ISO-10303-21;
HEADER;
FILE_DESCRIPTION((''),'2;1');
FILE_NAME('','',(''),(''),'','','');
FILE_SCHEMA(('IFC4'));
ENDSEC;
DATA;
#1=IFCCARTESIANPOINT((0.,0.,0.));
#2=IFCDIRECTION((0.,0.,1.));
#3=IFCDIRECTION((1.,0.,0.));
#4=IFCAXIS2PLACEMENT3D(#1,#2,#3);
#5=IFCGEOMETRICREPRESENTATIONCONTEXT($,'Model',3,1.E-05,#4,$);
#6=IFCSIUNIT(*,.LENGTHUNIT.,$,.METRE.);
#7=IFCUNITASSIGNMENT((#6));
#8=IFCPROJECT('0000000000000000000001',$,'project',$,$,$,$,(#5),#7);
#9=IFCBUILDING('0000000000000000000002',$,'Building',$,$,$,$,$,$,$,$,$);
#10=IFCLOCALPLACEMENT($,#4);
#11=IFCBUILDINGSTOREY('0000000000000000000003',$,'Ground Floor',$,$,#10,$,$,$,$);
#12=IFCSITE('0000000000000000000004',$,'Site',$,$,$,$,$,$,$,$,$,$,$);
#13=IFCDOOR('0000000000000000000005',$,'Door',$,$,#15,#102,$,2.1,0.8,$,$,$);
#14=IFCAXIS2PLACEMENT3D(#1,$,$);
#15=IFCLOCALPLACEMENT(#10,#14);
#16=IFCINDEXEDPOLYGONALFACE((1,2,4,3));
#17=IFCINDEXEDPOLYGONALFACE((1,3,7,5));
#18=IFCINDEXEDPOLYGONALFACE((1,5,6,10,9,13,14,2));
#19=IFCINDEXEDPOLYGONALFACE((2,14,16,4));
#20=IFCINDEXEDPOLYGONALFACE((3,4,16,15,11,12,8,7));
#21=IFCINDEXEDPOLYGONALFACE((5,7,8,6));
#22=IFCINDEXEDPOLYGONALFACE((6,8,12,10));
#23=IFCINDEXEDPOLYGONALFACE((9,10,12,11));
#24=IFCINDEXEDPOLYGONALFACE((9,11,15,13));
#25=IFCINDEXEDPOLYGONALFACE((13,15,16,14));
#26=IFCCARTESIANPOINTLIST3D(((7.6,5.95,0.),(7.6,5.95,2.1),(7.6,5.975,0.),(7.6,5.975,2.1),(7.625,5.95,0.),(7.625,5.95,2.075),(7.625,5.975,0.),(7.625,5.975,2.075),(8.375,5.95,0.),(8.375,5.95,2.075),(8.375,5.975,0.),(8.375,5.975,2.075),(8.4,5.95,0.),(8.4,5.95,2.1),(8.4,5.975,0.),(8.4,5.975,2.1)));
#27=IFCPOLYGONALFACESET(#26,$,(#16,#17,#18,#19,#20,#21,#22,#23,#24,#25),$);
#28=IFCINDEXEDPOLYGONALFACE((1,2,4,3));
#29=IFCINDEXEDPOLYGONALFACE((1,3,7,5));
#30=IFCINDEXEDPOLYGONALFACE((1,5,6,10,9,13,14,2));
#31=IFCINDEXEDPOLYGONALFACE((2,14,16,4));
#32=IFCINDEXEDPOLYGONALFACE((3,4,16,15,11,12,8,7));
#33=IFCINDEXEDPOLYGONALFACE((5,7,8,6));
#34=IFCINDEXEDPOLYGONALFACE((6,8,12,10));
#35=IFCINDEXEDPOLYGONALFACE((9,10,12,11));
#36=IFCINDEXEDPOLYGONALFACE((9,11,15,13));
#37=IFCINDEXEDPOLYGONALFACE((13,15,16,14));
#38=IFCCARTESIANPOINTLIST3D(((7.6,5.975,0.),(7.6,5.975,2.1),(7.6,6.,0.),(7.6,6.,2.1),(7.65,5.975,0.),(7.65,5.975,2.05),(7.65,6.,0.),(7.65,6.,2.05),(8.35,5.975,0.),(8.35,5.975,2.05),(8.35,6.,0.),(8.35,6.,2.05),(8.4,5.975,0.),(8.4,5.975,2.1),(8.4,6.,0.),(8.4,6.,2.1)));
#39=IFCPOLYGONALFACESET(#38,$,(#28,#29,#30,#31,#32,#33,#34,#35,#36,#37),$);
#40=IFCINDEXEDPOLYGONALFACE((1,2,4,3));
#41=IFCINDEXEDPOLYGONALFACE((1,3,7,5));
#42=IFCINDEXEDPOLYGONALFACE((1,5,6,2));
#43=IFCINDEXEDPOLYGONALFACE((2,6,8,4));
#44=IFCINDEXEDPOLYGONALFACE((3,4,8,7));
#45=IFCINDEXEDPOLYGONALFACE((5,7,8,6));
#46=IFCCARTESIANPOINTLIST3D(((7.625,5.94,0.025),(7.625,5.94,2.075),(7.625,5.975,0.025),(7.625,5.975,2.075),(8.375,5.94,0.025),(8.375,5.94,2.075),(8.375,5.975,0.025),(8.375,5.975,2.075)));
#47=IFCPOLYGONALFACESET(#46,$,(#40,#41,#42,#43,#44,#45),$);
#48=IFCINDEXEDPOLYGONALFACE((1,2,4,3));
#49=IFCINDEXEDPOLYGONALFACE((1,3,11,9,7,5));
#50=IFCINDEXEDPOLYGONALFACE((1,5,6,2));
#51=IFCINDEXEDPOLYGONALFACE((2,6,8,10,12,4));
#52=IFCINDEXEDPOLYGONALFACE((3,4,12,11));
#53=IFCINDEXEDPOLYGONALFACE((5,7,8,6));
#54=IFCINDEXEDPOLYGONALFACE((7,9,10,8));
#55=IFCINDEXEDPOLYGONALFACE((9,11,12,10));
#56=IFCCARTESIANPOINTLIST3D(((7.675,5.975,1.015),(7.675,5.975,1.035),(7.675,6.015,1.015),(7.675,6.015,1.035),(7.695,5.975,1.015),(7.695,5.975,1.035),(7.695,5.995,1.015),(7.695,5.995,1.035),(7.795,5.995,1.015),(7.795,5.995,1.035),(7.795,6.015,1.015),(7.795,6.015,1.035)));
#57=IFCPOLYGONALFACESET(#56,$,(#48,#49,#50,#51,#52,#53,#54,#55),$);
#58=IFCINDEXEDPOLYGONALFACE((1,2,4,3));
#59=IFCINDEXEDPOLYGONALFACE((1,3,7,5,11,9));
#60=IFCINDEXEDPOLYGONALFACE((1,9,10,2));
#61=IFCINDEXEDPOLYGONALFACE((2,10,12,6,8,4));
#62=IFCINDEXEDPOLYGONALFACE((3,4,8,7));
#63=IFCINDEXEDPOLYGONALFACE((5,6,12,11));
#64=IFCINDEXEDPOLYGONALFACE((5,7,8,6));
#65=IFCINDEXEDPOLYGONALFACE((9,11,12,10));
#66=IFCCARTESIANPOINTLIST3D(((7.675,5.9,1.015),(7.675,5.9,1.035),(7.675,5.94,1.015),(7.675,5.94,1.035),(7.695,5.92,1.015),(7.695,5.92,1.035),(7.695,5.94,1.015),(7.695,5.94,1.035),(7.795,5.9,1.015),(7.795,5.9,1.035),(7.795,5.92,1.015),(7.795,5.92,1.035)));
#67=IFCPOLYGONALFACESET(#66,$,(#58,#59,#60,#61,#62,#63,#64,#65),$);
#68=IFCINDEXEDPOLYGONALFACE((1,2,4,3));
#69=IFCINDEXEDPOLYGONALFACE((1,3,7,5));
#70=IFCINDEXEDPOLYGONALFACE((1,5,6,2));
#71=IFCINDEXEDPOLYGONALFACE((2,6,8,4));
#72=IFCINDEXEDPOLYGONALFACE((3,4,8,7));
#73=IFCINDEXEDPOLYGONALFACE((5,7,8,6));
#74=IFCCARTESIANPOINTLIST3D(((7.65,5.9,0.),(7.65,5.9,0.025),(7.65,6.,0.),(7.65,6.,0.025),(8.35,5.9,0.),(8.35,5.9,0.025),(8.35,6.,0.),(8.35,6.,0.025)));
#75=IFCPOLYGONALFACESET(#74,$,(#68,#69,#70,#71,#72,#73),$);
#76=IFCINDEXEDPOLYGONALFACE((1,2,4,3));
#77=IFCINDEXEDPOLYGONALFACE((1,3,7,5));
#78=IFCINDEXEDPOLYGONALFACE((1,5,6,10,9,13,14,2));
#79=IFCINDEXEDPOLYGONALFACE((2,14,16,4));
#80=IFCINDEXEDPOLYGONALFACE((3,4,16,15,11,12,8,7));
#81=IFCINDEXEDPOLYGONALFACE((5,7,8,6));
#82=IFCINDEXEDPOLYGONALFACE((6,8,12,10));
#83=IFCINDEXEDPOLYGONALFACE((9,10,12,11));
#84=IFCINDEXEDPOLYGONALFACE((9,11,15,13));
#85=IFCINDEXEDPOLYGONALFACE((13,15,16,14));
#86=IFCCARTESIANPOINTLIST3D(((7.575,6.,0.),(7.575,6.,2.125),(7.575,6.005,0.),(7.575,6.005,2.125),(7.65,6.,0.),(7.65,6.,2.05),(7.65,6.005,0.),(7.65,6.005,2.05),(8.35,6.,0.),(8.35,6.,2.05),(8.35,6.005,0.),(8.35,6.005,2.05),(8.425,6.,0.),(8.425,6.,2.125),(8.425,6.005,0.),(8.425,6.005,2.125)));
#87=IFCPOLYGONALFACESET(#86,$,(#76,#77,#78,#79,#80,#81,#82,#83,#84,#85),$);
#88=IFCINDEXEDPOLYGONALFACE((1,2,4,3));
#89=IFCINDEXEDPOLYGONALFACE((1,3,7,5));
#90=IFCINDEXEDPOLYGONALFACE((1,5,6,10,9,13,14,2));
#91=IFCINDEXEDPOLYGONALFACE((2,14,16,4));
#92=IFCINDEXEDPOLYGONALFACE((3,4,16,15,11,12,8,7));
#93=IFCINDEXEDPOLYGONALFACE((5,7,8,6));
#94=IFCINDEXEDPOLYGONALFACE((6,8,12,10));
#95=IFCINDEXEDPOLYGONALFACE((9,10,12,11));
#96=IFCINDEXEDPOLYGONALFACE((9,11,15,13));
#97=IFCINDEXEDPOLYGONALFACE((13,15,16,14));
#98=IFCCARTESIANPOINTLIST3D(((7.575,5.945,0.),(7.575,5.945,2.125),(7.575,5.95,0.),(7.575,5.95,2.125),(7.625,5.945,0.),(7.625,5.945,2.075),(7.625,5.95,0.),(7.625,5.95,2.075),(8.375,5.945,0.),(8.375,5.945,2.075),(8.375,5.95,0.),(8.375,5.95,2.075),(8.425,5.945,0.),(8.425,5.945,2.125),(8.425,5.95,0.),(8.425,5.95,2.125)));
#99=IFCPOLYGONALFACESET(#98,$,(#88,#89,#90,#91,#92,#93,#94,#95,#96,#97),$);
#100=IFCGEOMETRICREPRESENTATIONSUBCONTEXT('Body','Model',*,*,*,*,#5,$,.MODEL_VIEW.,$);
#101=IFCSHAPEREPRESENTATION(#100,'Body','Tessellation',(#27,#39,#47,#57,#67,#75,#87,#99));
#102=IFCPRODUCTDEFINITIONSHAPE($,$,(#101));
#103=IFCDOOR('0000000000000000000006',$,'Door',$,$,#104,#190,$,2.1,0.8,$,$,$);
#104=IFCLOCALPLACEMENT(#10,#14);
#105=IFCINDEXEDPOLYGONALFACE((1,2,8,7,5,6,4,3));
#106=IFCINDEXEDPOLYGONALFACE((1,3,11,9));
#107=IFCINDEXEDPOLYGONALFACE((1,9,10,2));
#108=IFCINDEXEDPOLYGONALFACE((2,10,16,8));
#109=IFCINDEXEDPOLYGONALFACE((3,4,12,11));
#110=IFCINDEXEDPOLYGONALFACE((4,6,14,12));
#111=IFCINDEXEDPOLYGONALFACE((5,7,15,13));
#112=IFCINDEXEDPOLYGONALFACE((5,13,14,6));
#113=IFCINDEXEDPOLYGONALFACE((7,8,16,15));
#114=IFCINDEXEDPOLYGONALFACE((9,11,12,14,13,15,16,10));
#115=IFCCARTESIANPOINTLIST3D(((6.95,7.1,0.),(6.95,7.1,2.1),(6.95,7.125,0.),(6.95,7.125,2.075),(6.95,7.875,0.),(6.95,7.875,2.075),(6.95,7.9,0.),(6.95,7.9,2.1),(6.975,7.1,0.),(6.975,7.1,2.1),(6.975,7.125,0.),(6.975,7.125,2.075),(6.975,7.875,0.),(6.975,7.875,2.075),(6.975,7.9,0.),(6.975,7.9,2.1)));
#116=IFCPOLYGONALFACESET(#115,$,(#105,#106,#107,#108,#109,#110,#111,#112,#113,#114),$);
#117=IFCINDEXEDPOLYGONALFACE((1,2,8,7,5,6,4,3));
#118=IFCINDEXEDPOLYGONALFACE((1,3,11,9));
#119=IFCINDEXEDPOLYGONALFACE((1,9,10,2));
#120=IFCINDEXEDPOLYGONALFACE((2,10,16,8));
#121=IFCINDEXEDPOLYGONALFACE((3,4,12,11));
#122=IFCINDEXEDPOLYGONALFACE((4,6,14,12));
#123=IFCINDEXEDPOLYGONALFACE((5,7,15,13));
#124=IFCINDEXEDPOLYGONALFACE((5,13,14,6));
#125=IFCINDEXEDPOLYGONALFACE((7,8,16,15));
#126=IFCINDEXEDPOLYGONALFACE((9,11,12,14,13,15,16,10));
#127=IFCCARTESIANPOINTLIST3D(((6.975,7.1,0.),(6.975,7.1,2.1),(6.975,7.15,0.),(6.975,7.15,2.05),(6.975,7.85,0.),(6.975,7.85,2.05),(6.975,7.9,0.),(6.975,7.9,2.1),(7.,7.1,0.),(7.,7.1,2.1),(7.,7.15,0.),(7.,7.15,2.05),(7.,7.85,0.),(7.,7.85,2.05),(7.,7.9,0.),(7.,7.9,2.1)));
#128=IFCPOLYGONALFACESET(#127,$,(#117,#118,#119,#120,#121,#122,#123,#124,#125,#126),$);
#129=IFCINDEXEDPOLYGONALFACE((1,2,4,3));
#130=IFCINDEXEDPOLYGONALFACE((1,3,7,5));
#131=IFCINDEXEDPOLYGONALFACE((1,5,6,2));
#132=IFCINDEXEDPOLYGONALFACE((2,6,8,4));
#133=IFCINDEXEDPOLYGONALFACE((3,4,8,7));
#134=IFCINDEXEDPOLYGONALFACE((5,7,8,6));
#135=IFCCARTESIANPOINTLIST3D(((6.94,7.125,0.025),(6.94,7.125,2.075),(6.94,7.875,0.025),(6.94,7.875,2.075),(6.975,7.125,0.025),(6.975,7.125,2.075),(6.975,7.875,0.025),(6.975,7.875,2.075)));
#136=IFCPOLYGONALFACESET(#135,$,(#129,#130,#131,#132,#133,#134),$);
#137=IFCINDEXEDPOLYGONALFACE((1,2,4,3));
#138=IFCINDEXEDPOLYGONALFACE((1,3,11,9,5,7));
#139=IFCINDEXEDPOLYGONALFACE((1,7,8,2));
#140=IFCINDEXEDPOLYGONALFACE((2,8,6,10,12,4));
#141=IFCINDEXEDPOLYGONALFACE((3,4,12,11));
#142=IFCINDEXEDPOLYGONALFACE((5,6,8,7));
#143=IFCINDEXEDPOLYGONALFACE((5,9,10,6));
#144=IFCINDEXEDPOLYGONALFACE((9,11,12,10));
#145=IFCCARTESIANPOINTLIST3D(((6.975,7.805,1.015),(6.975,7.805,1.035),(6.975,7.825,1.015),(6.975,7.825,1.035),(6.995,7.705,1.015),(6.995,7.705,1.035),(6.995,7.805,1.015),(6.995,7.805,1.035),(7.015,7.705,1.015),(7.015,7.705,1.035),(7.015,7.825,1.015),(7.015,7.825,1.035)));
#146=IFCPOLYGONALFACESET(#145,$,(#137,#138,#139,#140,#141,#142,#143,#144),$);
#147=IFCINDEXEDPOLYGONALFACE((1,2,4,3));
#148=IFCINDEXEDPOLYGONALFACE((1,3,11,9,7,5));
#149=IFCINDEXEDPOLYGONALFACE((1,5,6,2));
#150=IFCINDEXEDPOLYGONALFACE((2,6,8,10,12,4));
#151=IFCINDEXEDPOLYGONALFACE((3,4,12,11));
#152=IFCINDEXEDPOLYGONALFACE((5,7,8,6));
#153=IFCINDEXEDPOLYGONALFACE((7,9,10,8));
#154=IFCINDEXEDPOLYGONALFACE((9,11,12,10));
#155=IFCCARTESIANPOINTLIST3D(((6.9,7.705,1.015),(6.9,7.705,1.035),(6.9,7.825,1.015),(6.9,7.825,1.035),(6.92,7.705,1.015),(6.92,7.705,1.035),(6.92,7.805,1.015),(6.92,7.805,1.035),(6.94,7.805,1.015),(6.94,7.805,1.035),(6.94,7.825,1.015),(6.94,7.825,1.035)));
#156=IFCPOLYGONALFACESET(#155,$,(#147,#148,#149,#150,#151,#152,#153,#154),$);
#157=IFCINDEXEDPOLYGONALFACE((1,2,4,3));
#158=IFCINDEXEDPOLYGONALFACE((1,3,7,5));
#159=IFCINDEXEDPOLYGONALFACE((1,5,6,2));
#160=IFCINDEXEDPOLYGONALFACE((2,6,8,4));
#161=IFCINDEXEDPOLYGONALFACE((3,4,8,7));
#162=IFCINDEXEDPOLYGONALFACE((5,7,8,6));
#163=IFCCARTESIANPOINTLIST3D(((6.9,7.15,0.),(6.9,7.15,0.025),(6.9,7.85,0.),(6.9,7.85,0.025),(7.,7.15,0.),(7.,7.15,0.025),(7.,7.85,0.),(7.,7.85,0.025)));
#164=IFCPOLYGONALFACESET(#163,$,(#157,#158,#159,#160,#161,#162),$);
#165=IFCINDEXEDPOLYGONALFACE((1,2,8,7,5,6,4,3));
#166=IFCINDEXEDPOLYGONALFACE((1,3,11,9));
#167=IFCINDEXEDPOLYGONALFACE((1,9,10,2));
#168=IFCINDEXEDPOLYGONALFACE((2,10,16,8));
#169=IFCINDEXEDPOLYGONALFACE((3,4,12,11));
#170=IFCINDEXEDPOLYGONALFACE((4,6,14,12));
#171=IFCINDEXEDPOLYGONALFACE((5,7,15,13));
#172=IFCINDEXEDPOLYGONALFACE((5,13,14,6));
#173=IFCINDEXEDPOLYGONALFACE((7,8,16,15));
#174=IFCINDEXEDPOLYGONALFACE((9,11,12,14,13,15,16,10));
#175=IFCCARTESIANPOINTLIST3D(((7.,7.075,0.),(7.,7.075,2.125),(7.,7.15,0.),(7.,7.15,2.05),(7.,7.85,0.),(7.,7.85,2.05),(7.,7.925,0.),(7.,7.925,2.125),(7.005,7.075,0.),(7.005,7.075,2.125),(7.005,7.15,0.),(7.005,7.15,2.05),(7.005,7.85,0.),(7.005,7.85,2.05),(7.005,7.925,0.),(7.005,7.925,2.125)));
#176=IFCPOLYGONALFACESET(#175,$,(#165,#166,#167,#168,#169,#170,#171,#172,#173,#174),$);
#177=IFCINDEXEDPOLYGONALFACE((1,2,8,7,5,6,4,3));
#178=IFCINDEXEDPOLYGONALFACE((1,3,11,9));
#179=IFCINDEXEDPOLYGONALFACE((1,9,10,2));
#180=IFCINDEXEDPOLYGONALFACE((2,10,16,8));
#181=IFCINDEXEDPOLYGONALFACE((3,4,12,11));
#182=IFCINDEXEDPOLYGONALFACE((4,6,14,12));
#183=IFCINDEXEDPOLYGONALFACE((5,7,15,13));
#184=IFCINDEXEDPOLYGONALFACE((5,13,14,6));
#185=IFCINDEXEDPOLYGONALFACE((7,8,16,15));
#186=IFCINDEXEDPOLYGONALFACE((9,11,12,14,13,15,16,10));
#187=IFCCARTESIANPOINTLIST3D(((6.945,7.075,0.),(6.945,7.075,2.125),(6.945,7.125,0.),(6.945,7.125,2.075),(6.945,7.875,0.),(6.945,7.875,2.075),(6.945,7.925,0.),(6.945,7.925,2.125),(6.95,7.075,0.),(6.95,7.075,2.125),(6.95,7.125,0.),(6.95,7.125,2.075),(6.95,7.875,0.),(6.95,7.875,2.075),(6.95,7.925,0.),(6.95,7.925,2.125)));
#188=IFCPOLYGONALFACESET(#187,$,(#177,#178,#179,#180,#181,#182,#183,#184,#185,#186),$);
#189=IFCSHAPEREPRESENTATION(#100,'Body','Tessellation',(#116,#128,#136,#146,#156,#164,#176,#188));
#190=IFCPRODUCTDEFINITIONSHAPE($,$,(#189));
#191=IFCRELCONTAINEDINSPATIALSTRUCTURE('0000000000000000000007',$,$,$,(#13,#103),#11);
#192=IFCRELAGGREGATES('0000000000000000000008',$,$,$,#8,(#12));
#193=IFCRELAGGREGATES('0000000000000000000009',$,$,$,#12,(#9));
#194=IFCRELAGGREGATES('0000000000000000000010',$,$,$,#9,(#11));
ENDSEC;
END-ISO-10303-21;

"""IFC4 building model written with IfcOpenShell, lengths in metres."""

from ifc_helpers import new_model, si_unit, frame, origin_with_axes, place, context, subcontext, project, spatial, line, indexed_curve, outline, extrude, element, save


model = new_model("IFC4")

# Units and contexts
model_context = context("Model", 3, precision=1e-05, world=origin_with_axes())
body_context = subcontext(model_context, "Body", "Model", "MODEL_VIEW")
ifc_project = project(units=[si_unit("LENGTHUNIT", "METRE")], contexts=[model_context])

# Site, building, storey
site = spatial("IfcSite", under=ifc_project, Name="Site")
building = spatial("IfcBuilding", under=site, Name="Building")
storey_placement = place(None, origin_with_axes())
storey = spatial("IfcBuildingStorey", under=building, at=storey_placement, Name="Ground Floor")

# Doors
door_1_placement = place(storey_placement, frame((8.4, 6.0, 0.0), z_axis=(0.0, 0.0, 1.0), x_axis=(-1.0, 0.0, 0.0)))
element("IfcDoor", 1, at=door_1_placement, inside=storey, Name="Door", OverallHeight=2.1, OverallWidth=0.8, context=body_context, shape_type="SweptSolid", body=[
    extrude(outline(indexed_curve([(0.0, 0.0), (0.0, 2.1), (0.8, 2.1), (0.8, 0.0), (0.775, 0.0), (0.775, 2.075), (0.025, 2.075), (0.025, 0.0)], segments=[line(1, 2, 3, 4, 5, 6, 7, 8, 1)])), frame((0.0, 0.025, 0.0), z_axis=(0.0, -1.0, 0.0), x_axis=(1.0, 0.0, 0.0)), (0.0, 0.0, -1.0), 0.025),
    extrude(outline(indexed_curve([(0.0, 0.0), (0.0, 2.1), (0.8, 2.1), (0.8, 0.0), (0.75, 0.0), (0.75, 2.05), (0.05, 2.05), (0.05, 0.0)], segments=[line(1, 2, 3, 4, 5, 6, 7, 8, 1)])), frame((0.0, 0.0, 0.0), z_axis=(0.0, -1.0, 0.0), x_axis=(1.0, 0.0, 0.0)), (0.0, 0.0, -1.0), 0.025),
    extrude(outline(indexed_curve([(0.0, 0.0), (0.75, 0.0), (0.75, 0.035), (0.0, 0.035)], segments=[line(1, 2, 3, 4, 1)])), frame((0.025, 0.025, 0.025), z_axis=(0.0, 0.0, 1.0), x_axis=(1.0, 0.0, 0.0)), (0.0, 0.0, 1.0), 2.05),
    extrude(outline(indexed_curve([(0.0, 0.0), (0.0, -0.04), (-0.12, -0.04), (-0.12, -0.02), (-0.02, -0.02), (-0.02, 0.0)], segments=[line(1, 2, 3, 4, 5, 6, 1)])), frame((0.725, 0.025, 1.015), z_axis=(0.0, 0.0, 1.0), x_axis=(1.0, 0.0, 0.0)), (0.0, 0.0, 1.0), 0.02),
    extrude(outline(indexed_curve([(0.0, 0.0), (0.0, 0.04), (-0.12, 0.04), (-0.12, 0.02), (-0.02, 0.02), (-0.02, 0.0)], segments=[line(1, 2, 3, 4, 5, 6, 1)])), frame((0.725, 0.06, 1.015), z_axis=(0.0, 0.0, 1.0), x_axis=(1.0, 0.0, 0.0)), (0.0, 0.0, 1.0), 0.02),
    extrude(outline(indexed_curve([(0.0, 0.0), (0.7, 0.0), (0.7, 0.1), (0.0, 0.1)], segments=[line(1, 2, 3, 4, 1)])), frame((0.05, 0.0, 0.0), z_axis=(0.0, 0.0, 1.0), x_axis=(1.0, 0.0, 0.0)), (0.0, 0.0, 1.0), 0.025),
    extrude(outline(indexed_curve([(0.0, 0.0), (0.0, 2.125), (0.85, 2.125), (0.85, 0.0), (0.775, 0.0), (0.775, 2.05), (0.075, 2.05), (0.075, 0.0)], segments=[line(1, 2, 3, 4, 5, 6, 7, 8, 1)])), frame((-0.025, -0.005, 0.0), z_axis=(0.0, -1.0, 0.0), x_axis=(1.0, 0.0, 0.0)), (0.0, 0.0, -1.0), 0.005),
    extrude(outline(indexed_curve([(0.0, 0.0), (0.0, 2.125), (0.85, 2.125), (0.85, 0.0), (0.8, 0.0), (0.8, 2.075), (0.05, 2.075), (0.05, 0.0)], segments=[line(1, 2, 3, 4, 5, 6, 7, 8, 1)])), frame((-0.025, 0.05, 0.0), z_axis=(0.0, -1.0, 0.0), x_axis=(1.0, 0.0, 0.0)), (0.0, 0.0, -1.0), 0.005),
])
door_2_placement = place(storey_placement, frame((7.0, 7.1, 0.0), z_axis=(0.0, 0.0, 1.0), x_axis=(0.0, 1.0, 0.0)))
element("IfcDoor", 2, at=door_2_placement, inside=storey, Name="Door", OverallHeight=2.1, OverallWidth=0.8, context=body_context, shape_type="SweptSolid", body=[
    extrude(outline(indexed_curve([(0.0, 0.0), (0.0, 2.1), (0.8, 2.1), (0.8, 0.0), (0.775, 0.0), (0.775, 2.075), (0.025, 2.075), (0.025, 0.0)], segments=[line(1, 2, 3, 4, 5, 6, 7, 8, 1)])), frame((0.0, 0.025, 0.0), z_axis=(0.0, -1.0, 0.0), x_axis=(1.0, 0.0, 0.0)), (0.0, 0.0, -1.0), 0.025),
    extrude(outline(indexed_curve([(0.0, 0.0), (0.0, 2.1), (0.8, 2.1), (0.8, 0.0), (0.75, 0.0), (0.75, 2.05), (0.05, 2.05), (0.05, 0.0)], segments=[line(1, 2, 3, 4, 5, 6, 7, 8, 1)])), frame((0.0, 0.0, 0.0), z_axis=(0.0, -1.0, 0.0), x_axis=(1.0, 0.0, 0.0)), (0.0, 0.0, -1.0), 0.025),
    extrude(outline(indexed_curve([(0.0, 0.0), (0.75, 0.0), (0.75, 0.035), (0.0, 0.035)], segments=[line(1, 2, 3, 4, 1)])), frame((0.025, 0.025, 0.025), z_axis=(0.0, 0.0, 1.0), x_axis=(1.0, 0.0, 0.0)), (0.0, 0.0, 1.0), 2.05),
    extrude(outline(indexed_curve([(0.0, 0.0), (0.0, -0.04), (-0.12, -0.04), (-0.12, -0.02), (-0.02, -0.02), (-0.02, 0.0)], segments=[line(1, 2, 3, 4, 5, 6, 1)])), frame((0.725, 0.025, 1.015), z_axis=(0.0, 0.0, 1.0), x_axis=(1.0, 0.0, 0.0)), (0.0, 0.0, 1.0), 0.02),
    extrude(outline(indexed_curve([(0.0, 0.0), (0.0, 0.04), (-0.12, 0.04), (-0.12, 0.02), (-0.02, 0.02), (-0.02, 0.0)], segments=[line(1, 2, 3, 4, 5, 6, 1)])), frame((0.725, 0.06, 1.015), z_axis=(0.0, 0.0, 1.0), x_axis=(1.0, 0.0, 0.0)), (0.0, 0.0, 1.0), 0.02),
    extrude(outline(indexed_curve([(0.0, 0.0), (0.7, 0.0), (0.7, 0.1), (0.0, 0.1)], segments=[line(1, 2, 3, 4, 1)])), frame((0.05, 0.0, 0.0), z_axis=(0.0, 0.0, 1.0), x_axis=(1.0, 0.0, 0.0)), (0.0, 0.0, 1.0), 0.025),
    extrude(outline(indexed_curve([(0.0, 0.0), (0.0, 2.125), (0.85, 2.125), (0.85, 0.0), (0.775, 0.0), (0.775, 2.05), (0.075, 2.05), (0.075, 0.0)], segments=[line(1, 2, 3, 4, 5, 6, 7, 8, 1)])), frame((-0.025, -0.005, 0.0), z_axis=(0.0, -1.0, 0.0), x_axis=(1.0, 0.0, 0.0)), (0.0, 0.0, -1.0), 0.005),
    extrude(outline(indexed_curve([(0.0, 0.0), (0.0, 2.125), (0.85, 2.125), (0.85, 0.0), (0.8, 0.0), (0.8, 2.075), (0.05, 2.075), (0.05, 0.0)], segments=[line(1, 2, 3, 4, 5, 6, 7, 8, 1)])), frame((-0.025, 0.05, 0.0), z_axis=(0.0, -1.0, 0.0), x_axis=(1.0, 0.0, 0.0)), (0.0, 0.0, -1.0), 0.005),
])

save(model, "model.ifc")
